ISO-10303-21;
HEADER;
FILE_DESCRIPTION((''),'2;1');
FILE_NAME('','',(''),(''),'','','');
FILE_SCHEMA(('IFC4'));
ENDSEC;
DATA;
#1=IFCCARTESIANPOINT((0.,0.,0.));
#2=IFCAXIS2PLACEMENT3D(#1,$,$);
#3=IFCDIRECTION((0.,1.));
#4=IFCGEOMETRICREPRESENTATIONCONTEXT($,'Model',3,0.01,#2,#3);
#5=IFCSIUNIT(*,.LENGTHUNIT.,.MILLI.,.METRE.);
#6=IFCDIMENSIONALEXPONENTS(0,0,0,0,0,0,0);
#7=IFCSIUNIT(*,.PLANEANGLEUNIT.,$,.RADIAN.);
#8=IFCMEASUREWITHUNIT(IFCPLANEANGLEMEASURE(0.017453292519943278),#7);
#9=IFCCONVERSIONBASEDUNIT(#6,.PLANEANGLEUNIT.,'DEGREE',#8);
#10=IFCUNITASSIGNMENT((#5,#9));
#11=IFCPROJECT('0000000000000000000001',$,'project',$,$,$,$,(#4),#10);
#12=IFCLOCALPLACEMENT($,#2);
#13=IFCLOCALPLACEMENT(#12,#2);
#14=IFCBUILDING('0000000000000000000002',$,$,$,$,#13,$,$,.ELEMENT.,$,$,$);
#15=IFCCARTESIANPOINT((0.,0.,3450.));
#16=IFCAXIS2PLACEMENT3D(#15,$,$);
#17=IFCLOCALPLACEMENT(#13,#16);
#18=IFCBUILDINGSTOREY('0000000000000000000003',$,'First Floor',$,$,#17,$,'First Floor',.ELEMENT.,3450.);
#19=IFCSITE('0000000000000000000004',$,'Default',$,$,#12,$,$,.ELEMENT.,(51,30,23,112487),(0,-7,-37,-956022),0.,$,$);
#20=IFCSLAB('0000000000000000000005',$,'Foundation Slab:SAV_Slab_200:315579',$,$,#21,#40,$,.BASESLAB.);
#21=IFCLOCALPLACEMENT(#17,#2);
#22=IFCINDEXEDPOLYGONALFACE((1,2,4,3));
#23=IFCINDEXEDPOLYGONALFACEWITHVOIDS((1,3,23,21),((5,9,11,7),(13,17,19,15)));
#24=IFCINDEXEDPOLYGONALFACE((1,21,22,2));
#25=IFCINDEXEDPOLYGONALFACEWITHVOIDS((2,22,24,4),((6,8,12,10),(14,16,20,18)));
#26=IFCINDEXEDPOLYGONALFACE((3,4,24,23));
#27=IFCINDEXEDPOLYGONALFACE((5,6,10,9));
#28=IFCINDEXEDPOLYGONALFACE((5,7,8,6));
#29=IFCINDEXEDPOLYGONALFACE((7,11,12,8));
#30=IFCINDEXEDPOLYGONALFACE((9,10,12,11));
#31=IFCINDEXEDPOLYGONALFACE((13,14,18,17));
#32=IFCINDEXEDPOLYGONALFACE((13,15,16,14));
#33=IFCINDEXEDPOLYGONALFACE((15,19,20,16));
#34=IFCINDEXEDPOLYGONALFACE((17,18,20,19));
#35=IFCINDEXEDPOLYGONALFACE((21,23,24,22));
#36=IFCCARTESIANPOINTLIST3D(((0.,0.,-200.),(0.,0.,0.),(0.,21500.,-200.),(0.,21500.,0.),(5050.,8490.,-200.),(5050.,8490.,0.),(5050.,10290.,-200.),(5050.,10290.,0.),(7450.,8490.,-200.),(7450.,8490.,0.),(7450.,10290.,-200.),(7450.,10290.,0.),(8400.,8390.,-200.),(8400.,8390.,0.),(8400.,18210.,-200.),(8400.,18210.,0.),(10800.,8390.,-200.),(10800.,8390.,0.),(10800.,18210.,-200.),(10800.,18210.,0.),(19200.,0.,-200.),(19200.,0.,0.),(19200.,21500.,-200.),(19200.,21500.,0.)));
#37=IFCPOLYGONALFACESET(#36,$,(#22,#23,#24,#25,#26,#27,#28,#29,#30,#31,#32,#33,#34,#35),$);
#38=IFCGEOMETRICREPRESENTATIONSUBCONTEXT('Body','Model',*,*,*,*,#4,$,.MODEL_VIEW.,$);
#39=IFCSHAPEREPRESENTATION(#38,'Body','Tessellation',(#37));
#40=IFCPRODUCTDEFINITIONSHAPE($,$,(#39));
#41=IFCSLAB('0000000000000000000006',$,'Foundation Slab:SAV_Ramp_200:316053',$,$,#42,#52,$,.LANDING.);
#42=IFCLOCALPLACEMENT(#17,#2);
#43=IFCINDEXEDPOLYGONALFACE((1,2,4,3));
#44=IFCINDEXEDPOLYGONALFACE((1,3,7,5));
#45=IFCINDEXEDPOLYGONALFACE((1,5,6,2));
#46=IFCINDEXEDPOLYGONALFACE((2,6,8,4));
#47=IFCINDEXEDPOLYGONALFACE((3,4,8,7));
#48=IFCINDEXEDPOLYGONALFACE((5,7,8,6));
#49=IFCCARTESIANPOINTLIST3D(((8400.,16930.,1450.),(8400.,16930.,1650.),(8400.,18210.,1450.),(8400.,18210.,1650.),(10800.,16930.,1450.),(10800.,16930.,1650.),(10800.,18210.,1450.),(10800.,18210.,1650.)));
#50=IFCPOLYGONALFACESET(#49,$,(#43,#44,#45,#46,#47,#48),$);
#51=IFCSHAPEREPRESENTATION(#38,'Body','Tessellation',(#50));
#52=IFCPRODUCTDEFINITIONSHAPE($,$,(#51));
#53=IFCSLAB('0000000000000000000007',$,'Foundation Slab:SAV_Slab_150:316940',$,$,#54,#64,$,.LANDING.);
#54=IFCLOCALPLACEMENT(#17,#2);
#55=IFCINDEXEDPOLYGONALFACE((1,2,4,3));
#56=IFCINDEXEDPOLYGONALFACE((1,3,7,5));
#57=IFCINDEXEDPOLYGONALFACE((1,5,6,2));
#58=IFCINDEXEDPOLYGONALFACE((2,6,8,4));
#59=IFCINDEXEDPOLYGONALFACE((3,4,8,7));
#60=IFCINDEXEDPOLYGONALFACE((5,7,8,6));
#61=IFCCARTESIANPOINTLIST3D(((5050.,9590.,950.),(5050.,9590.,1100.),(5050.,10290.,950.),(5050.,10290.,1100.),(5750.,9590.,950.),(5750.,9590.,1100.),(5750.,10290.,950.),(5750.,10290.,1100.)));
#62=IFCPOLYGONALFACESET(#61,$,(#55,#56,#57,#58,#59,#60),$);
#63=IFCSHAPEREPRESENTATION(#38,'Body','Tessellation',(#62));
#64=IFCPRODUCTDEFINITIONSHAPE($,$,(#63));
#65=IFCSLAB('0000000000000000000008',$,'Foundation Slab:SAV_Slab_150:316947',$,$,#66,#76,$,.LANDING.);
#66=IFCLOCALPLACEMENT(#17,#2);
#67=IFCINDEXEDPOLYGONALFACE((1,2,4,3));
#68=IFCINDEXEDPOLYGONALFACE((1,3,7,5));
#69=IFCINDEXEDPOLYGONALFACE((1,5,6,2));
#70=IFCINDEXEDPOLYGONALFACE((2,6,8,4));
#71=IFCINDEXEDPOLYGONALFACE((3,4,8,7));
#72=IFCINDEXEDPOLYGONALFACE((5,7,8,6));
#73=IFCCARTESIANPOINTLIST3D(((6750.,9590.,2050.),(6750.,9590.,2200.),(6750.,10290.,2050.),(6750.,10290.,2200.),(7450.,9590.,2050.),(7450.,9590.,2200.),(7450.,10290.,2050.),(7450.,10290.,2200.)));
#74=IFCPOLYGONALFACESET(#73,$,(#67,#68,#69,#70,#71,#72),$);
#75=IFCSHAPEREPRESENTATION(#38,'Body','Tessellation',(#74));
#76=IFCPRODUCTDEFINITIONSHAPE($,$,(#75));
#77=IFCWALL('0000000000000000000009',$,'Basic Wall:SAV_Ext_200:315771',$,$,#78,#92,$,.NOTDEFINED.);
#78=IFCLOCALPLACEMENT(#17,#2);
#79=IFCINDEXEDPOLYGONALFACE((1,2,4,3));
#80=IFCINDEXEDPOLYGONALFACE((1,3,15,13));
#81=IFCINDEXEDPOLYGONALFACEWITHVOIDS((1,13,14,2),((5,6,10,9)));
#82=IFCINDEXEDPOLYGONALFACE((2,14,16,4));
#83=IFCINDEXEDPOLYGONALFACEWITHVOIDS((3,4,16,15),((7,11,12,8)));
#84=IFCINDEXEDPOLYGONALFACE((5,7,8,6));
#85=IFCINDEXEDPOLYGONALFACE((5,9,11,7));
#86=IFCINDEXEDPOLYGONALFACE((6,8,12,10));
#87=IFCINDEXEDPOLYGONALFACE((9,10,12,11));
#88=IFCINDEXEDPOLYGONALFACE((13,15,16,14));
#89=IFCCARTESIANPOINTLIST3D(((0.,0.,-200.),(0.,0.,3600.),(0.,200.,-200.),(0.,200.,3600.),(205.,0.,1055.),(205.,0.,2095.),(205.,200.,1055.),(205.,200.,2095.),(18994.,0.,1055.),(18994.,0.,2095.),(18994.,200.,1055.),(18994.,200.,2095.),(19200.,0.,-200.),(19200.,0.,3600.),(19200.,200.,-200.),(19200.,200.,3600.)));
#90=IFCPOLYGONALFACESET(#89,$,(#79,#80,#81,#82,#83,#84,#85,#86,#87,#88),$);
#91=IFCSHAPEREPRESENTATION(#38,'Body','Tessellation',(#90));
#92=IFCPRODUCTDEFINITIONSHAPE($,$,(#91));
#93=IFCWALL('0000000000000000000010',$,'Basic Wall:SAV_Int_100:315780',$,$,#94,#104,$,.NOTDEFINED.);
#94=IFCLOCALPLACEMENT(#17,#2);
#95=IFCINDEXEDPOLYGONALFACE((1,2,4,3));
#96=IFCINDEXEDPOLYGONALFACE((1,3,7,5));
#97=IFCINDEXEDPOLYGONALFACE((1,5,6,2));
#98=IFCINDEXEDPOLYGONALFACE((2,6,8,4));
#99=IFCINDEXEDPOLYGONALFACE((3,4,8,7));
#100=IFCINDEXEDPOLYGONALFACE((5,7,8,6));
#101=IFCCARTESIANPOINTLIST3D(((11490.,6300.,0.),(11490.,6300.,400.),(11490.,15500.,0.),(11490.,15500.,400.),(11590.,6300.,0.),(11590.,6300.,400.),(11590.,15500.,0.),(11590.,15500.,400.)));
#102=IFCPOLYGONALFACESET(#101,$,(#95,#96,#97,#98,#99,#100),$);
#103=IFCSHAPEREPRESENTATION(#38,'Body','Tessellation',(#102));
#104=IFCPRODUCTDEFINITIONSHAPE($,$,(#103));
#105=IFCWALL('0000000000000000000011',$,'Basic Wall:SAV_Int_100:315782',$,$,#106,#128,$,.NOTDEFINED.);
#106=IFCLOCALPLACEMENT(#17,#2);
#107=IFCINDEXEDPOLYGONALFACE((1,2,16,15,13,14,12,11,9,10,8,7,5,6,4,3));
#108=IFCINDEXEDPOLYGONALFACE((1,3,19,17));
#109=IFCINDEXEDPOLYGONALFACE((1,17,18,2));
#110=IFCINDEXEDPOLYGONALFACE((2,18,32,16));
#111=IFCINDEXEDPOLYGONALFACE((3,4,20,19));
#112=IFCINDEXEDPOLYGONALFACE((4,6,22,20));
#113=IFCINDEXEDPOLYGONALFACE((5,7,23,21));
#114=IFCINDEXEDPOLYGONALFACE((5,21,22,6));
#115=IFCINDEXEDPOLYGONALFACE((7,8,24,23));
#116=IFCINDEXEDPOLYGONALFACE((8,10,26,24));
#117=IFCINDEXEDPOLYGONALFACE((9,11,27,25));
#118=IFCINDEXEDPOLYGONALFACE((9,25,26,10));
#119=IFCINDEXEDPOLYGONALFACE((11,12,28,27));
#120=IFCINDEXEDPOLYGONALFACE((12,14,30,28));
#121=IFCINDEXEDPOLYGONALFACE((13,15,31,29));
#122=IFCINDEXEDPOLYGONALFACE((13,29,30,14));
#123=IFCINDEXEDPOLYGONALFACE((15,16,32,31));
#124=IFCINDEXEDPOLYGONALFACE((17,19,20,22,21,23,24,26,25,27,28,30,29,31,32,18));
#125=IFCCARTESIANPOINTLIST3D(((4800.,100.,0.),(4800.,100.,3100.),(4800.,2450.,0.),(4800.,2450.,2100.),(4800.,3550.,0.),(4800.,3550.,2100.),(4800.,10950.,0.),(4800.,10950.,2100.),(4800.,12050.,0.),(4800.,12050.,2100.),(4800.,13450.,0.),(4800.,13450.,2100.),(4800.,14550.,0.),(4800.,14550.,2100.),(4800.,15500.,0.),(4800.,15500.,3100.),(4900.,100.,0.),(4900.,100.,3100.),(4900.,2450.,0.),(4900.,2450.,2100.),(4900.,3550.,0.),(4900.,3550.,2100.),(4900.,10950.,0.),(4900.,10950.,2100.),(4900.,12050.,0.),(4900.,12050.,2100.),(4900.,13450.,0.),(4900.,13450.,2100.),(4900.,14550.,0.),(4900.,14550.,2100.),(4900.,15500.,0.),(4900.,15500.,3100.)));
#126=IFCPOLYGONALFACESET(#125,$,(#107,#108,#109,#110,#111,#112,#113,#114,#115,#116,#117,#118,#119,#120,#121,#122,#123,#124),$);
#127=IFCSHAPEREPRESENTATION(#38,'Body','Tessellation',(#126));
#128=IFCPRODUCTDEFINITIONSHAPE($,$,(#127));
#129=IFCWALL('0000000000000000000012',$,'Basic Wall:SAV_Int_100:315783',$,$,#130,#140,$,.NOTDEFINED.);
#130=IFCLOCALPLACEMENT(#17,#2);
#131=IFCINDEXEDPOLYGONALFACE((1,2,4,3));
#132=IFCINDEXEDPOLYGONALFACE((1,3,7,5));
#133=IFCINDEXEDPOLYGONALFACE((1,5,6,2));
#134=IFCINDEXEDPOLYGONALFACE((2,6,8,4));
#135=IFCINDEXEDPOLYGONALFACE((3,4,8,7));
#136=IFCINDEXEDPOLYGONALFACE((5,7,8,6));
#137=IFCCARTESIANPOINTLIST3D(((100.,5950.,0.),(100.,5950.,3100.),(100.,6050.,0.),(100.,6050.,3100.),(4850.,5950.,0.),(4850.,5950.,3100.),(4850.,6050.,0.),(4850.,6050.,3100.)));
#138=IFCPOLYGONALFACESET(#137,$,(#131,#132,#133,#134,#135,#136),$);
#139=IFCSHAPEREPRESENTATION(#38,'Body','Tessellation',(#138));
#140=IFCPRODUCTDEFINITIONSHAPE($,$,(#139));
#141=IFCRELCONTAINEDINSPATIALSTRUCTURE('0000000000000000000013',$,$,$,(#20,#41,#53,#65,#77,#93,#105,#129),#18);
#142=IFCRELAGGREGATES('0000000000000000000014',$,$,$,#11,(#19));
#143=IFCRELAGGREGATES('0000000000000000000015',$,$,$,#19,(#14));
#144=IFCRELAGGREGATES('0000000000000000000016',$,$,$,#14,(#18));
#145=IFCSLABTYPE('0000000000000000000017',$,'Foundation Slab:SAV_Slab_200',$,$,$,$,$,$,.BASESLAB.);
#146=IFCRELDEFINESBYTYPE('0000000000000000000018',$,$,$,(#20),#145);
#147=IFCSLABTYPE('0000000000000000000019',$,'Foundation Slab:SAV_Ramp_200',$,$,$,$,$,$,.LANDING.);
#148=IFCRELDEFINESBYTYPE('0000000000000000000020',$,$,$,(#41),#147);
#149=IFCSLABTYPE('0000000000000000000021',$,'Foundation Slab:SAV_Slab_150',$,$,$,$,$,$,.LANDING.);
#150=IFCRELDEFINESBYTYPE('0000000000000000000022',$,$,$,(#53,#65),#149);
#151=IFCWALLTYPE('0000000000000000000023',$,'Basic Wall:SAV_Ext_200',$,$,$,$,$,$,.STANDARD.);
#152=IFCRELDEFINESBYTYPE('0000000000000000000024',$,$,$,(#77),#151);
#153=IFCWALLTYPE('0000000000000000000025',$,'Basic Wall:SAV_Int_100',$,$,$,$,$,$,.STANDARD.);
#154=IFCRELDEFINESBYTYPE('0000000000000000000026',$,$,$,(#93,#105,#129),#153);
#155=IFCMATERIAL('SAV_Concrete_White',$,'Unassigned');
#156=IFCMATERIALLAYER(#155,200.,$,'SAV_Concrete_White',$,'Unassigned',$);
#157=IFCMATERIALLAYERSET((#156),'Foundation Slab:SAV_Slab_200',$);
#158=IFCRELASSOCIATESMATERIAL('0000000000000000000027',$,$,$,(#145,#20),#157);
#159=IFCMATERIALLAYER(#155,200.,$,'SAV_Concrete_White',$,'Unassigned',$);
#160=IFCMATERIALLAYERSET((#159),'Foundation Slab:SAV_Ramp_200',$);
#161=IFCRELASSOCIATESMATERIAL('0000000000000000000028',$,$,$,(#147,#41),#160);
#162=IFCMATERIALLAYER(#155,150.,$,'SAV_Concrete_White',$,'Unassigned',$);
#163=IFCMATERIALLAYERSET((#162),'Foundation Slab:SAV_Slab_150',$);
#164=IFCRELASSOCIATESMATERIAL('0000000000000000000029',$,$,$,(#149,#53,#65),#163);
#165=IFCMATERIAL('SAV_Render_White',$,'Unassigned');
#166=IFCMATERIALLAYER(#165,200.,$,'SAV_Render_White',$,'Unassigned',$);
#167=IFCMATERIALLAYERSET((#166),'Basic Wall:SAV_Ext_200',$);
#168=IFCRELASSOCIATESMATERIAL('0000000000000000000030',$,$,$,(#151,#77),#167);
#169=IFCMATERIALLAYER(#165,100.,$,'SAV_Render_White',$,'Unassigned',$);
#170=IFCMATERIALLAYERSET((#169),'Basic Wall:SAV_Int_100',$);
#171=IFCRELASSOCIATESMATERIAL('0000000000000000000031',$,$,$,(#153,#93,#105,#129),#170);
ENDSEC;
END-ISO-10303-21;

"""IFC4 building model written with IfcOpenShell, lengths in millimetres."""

from ifc_helpers import new_model, entity, si_unit, converted_unit, direction, frame, frame_2d, origin, origin_2d_with_axis, place, context, subcontext, project, spatial, rectangle, extrude, boolean, material, layer, layer_set, layer_usage, type_object, element, save


model = new_model("IFC4")

# Units and contexts
model_context = context("Model", 3, precision=0.01, world=origin(), true_north=direction((0.0, 1.0)))
body_context = subcontext(model_context, "Body", "Model", "MODEL_VIEW")
ifc_project = project(units=[si_unit("LENGTHUNIT", "METRE", prefix="MILLI"), converted_unit("PLANEANGLEUNIT", "DEGREE", entity("IfcPlaneAngleMeasure", 0.017453292519943278), si_unit("PLANEANGLEUNIT", "RADIAN"), dimensions=[0, 0, 0, 0, 0, 0, 0])], contexts=[model_context])

# Site, building, storey
site_placement = place(None, origin())
site = spatial("IfcSite", under=ifc_project, at=site_placement, Name="Default", CompositionType="ELEMENT", RefLatitude=(51, 30, 23, 112487), RefLongitude=(0, -7, -37, -956022), RefElevation=0.0)
building_placement = place(site_placement, origin())
building = spatial("IfcBuilding", under=site, at=building_placement, CompositionType="ELEMENT")
storey_placement = place(building_placement, frame((0.0, 0.0, 3450.0)))
storey = spatial("IfcBuildingStorey", under=building, at=storey_placement, Name="First Floor", LongName="First Floor", CompositionType="ELEMENT", Elevation=3450.0)

# Slab, openings
ifc_material_1 = material(Name="SAV_Concrete_White", Category="Unassigned")
ifc_layer_1 = layer(ifc_material_1, 200.0, Name="SAV_Concrete_White", Category="Unassigned")
ifc_layer_set_1 = layer_set([ifc_layer_1], Name="Foundation Slab:SAV_Slab_200")
ifc_layer_usage_1 = layer_usage(ifc_layer_set_1, "AXIS3", "POSITIVE", 0.0)
slab_type_1 = type_object("IfcSlabType", Name="Foundation Slab:SAV_Slab_200", PredefinedType="BASESLAB", material=ifc_layer_set_1)
slab_1_placement = place(storey_placement, origin())
slab_1 = element("IfcSlab", 1, at=slab_1_placement, inside=storey, type_object=slab_type_1, material=ifc_layer_usage_1, Name="Foundation Slab:SAV_Slab_200:315579", PredefinedType="BASESLAB", context=body_context, shape_type="CSG", body=[
    boolean("DIFFERENCE", boolean("DIFFERENCE", extrude(rectangle(XDim=21500.0, YDim=19200.0, at=origin_2d_with_axis()), frame((9600.0, 10750.0, 0.0), z_axis=(0.0, 0.0, -1.0), x_axis=(0.0, 1.0, 0.0)), (0.0, 0.0, 1.0), 200.0), extrude(rectangle(XDim=1800.0, YDim=2400.0, at=frame_2d((0.0, 0.0), x_axis=(1.0, 0.0))), frame((6250.0, 9390.0, -200.0), z_axis=(0.0, 0.0, 1.0), x_axis=(0.0, 1.0, 0.0)), (0.0, 0.0, 1.0), 200.0)), extrude(rectangle(XDim=9820.0, YDim=2400.0, at=frame_2d((0.0, 0.0), x_axis=(1.0, 0.0))), frame((9600.0, 13300.0, -200.0), z_axis=(0.0, 0.0, 1.0), x_axis=(0.0, 1.0, 0.0)), (0.0, 0.0, 1.0), 200.0)),
])
opening_1_placement = place(slab_1_placement, origin())
element("IfcOpeningElement", 2, at=opening_1_placement, cuts=slab_1, PredefinedType="OPENING", context=body_context, shape_type="SweptSolid", body=[
    extrude(rectangle(XDim=2400.0, YDim=9820.0, at=frame_2d((9600.0, 13300.0), x_axis=(-1.0, 0.0))), origin(), (0.0, 0.0, -1.0), 200.0),
])
opening_2_placement = place(slab_1_placement, origin())
element("IfcOpeningElement", 3, at=opening_2_placement, cuts=slab_1, PredefinedType="OPENING", context=body_context, shape_type="SweptSolid", body=[
    extrude(rectangle(XDim=2400.0, YDim=1800.0, at=frame_2d((6250.0, 9390.0), x_axis=(-1.0, 0.0))), origin(), (0.0, 0.0, -1.0), 200.0),
])

# Slabs
ifc_layer_2 = layer(ifc_material_1, 200.0, Name="SAV_Concrete_White", Category="Unassigned")
ifc_layer_set_2 = layer_set([ifc_layer_2], Name="Foundation Slab:SAV_Ramp_200")
ifc_layer_usage_2 = layer_usage(ifc_layer_set_2, "AXIS3", "POSITIVE", 0.0)
slab_type_2 = type_object("IfcSlabType", Name="Foundation Slab:SAV_Ramp_200", PredefinedType="LANDING", material=ifc_layer_set_2)
slab_2_placement = place(storey_placement, origin())
element("IfcSlab", 4, at=slab_2_placement, inside=storey, type_object=slab_type_2, material=ifc_layer_usage_2, Name="Foundation Slab:SAV_Ramp_200:316053", PredefinedType="LANDING", context=body_context, shape_type="SweptSolid", body=[
    extrude(rectangle(XDim=1280.0, YDim=2400.0, at=frame_2d((0.0, 0.0), x_axis=(1.0, 0.0))), frame((9600.0, 17570.0, 1650.0), z_axis=(0.0, 0.0, -1.0), x_axis=(0.0, 1.0, 0.0)), (0.0, 0.0, 1.0), 200.0),
])
ifc_layer_3 = layer(ifc_material_1, 150.0, Name="SAV_Concrete_White", Category="Unassigned")
ifc_layer_set_3 = layer_set([ifc_layer_3], Name="Foundation Slab:SAV_Slab_150")
ifc_layer_usage_3 = layer_usage(ifc_layer_set_3, "AXIS3", "POSITIVE", 0.0)
slab_type_3 = type_object("IfcSlabType", Name="Foundation Slab:SAV_Slab_150", PredefinedType="LANDING", material=ifc_layer_set_3)
slab_3_placement = place(storey_placement, origin())
element("IfcSlab", 5, at=slab_3_placement, inside=storey, type_object=slab_type_3, material=ifc_layer_usage_3, Name="Foundation Slab:SAV_Slab_150:316940", PredefinedType="LANDING", context=body_context, shape_type="SweptSolid", body=[
    extrude(rectangle(XDim=700.0, YDim=700.0, at=frame_2d((0.0, 0.0), x_axis=(1.0, 0.0))), frame((5400.0, 9940.0, 1100.0), z_axis=(0.0, 0.0, -1.0), x_axis=(0.0, 1.0, 0.0)), (0.0, 0.0, 1.0), 150.0),
])
ifc_layer_usage_4 = layer_usage(ifc_layer_set_3, "AXIS3", "POSITIVE", 0.0)
slab_4_placement = place(storey_placement, origin())
element("IfcSlab", 6, at=slab_4_placement, inside=storey, type_object=slab_type_3, material=ifc_layer_usage_4, Name="Foundation Slab:SAV_Slab_150:316947", PredefinedType="LANDING", context=body_context, shape_type="SweptSolid", body=[
    extrude(rectangle(XDim=700.0, YDim=700.0, at=frame_2d((0.0, 0.0), x_axis=(1.0, 0.0))), frame((7100.0, 9940.0, 2200.0), z_axis=(0.0, 0.0, -1.0), x_axis=(0.0, 1.0, 0.0)), (0.0, 0.0, 1.0), 150.0),
])

# Wall, opening
ifc_material_2 = material(Name="SAV_Render_White", Category="Unassigned")
ifc_layer_4 = layer(ifc_material_2, 200.0, Name="SAV_Render_White", Category="Unassigned")
ifc_layer_set_4 = layer_set([ifc_layer_4], Name="Basic Wall:SAV_Ext_200")
ifc_layer_usage_5 = layer_usage(ifc_layer_set_4, "AXIS2", "NEGATIVE", 100.0)
wall_type_1 = type_object("IfcWallType", Name="Basic Wall:SAV_Ext_200", PredefinedType="STANDARD", material=ifc_layer_set_4)
wall_1_placement = place(storey_placement, frame((0.0, 100.0, -200.0)))
wall_1 = element("IfcWall", 7, at=wall_1_placement, inside=storey, type_object=wall_type_1, material=ifc_layer_usage_5, Name="Basic Wall:SAV_Ext_200:315771", PredefinedType="NOTDEFINED", context=body_context, shape_type="SweptSolid", body=[
    extrude(rectangle(XDim=19200.0, YDim=200.0, at=frame_2d((9600.0, 0.0), x_axis=(-1.0, 0.0))), origin(), (0.0, 0.0, 1.0), 3800.0),
])
opening_3_placement = place(wall_1_placement, frame((205.0, -100.0, 1255.0)))
element("IfcOpeningElement", 8, at=opening_3_placement, cuts=wall_1, PredefinedType="OPENING", context=body_context, shape_type="SweptSolid", body=[
    extrude(rectangle(XDim=1040.0, YDim=18789.0, at=frame_2d((520.0, 9394.5), x_axis=(-1.0, 0.0))), frame((0.0, 0.0, 0.0), z_axis=(0.0, 1.0, 0.0), x_axis=(0.0, 0.0, 1.0)), (0.0, 0.0, 1.0), 200.0),
])

# Wall
ifc_layer_5 = layer(ifc_material_2, 100.0, Name="SAV_Render_White", Category="Unassigned")
ifc_layer_set_5 = layer_set([ifc_layer_5], Name="Basic Wall:SAV_Int_100")
ifc_layer_usage_6 = layer_usage(ifc_layer_set_5, "AXIS2", "NEGATIVE", 50.0)
wall_type_2 = type_object("IfcWallType", Name="Basic Wall:SAV_Int_100", PredefinedType="STANDARD", material=ifc_layer_set_5)
wall_2_placement = place(storey_placement, frame((11540.0, 6300.0, 0.0), z_axis=(0.0, 0.0, 1.0), x_axis=(0.0, 1.0, 0.0)))
element("IfcWall", 9, at=wall_2_placement, inside=storey, type_object=wall_type_2, material=ifc_layer_usage_6, Name="Basic Wall:SAV_Int_100:315780", PredefinedType="NOTDEFINED", context=body_context, shape_type="SweptSolid", body=[
    extrude(rectangle(XDim=9200.0, YDim=100.0, at=frame_2d((4600.0, 0.0), x_axis=(-1.0, 0.0))), origin(), (0.0, 0.0, 1.0), 400.0),
])

# Wall, openings
ifc_layer_usage_7 = layer_usage(ifc_layer_set_5, "AXIS2", "NEGATIVE", 50.0)
wall_3_placement = place(storey_placement, frame((4850.0, 100.0, 0.0), z_axis=(0.0, 0.0, 1.0), x_axis=(0.0, 1.0, 0.0)))
wall_3 = element("IfcWall", 10, at=wall_3_placement, inside=storey, type_object=wall_type_2, material=ifc_layer_usage_7, Name="Basic Wall:SAV_Int_100:315782", PredefinedType="NOTDEFINED", context=body_context, shape_type="SweptSolid", body=[
    extrude(rectangle(XDim=15400.0, YDim=100.0, at=frame_2d((7700.0, 0.0), x_axis=(1.0, 0.0))), origin(), (0.0, 0.0, 1.0), 3100.0),
])
opening_4_placement = place(wall_3_placement, frame((13350.0, -50.0, 0.0)))
element("IfcOpeningElement", 11, at=opening_4_placement, cuts=wall_3, PredefinedType="OPENING", context=body_context, shape_type="SweptSolid", body=[
    extrude(rectangle(XDim=2100.0, YDim=1100.0, at=frame_2d((1050.0, 550.0), x_axis=(1.0, 0.0))), frame((0.0, 0.0, 0.0), z_axis=(0.0, 1.0, 0.0), x_axis=(0.0, 0.0, 1.0)), (0.0, 0.0, 1.0), 100.0),
])
opening_5_placement = place(wall_3_placement, frame((10850.0, -50.0, 0.0)))
element("IfcOpeningElement", 12, at=opening_5_placement, cuts=wall_3, PredefinedType="OPENING", context=body_context, shape_type="SweptSolid", body=[
    extrude(rectangle(XDim=2100.0, YDim=1100.0, at=frame_2d((1050.0, 550.0), x_axis=(1.0, 0.0))), frame((0.0, 0.0, 0.0), z_axis=(0.0, 1.0, 0.0), x_axis=(0.0, 0.0, 1.0)), (0.0, 0.0, 1.0), 100.0),
])
opening_6_placement = place(wall_3_placement, frame((2350.0, -50.0, 0.0)))
element("IfcOpeningElement", 13, at=opening_6_placement, cuts=wall_3, PredefinedType="OPENING", context=body_context, shape_type="SweptSolid", body=[
    extrude(rectangle(XDim=2100.0, YDim=1100.0, at=frame_2d((1050.0, 550.0), x_axis=(1.0, 0.0))), frame((0.0, 0.0, 0.0), z_axis=(0.0, 1.0, 0.0), x_axis=(0.0, 0.0, 1.0)), (0.0, 0.0, 1.0), 100.0),
])

# Wall
ifc_layer_usage_8 = layer_usage(ifc_layer_set_5, "AXIS2", "NEGATIVE", 50.0)
wall_4_placement = place(storey_placement, frame((100.0, 6000.0, 0.0)))
element("IfcWall", 14, at=wall_4_placement, inside=storey, type_object=wall_type_2, material=ifc_layer_usage_8, Name="Basic Wall:SAV_Int_100:315783", PredefinedType="NOTDEFINED", context=body_context, shape_type="SweptSolid", body=[
    extrude(rectangle(XDim=4750.0, YDim=100.0, at=frame_2d((2375.0, 0.0), x_axis=(-1.0, 0.0))), origin(), (0.0, 0.0, 1.0), 3100.0),
])

save(model, "model.ifc")
